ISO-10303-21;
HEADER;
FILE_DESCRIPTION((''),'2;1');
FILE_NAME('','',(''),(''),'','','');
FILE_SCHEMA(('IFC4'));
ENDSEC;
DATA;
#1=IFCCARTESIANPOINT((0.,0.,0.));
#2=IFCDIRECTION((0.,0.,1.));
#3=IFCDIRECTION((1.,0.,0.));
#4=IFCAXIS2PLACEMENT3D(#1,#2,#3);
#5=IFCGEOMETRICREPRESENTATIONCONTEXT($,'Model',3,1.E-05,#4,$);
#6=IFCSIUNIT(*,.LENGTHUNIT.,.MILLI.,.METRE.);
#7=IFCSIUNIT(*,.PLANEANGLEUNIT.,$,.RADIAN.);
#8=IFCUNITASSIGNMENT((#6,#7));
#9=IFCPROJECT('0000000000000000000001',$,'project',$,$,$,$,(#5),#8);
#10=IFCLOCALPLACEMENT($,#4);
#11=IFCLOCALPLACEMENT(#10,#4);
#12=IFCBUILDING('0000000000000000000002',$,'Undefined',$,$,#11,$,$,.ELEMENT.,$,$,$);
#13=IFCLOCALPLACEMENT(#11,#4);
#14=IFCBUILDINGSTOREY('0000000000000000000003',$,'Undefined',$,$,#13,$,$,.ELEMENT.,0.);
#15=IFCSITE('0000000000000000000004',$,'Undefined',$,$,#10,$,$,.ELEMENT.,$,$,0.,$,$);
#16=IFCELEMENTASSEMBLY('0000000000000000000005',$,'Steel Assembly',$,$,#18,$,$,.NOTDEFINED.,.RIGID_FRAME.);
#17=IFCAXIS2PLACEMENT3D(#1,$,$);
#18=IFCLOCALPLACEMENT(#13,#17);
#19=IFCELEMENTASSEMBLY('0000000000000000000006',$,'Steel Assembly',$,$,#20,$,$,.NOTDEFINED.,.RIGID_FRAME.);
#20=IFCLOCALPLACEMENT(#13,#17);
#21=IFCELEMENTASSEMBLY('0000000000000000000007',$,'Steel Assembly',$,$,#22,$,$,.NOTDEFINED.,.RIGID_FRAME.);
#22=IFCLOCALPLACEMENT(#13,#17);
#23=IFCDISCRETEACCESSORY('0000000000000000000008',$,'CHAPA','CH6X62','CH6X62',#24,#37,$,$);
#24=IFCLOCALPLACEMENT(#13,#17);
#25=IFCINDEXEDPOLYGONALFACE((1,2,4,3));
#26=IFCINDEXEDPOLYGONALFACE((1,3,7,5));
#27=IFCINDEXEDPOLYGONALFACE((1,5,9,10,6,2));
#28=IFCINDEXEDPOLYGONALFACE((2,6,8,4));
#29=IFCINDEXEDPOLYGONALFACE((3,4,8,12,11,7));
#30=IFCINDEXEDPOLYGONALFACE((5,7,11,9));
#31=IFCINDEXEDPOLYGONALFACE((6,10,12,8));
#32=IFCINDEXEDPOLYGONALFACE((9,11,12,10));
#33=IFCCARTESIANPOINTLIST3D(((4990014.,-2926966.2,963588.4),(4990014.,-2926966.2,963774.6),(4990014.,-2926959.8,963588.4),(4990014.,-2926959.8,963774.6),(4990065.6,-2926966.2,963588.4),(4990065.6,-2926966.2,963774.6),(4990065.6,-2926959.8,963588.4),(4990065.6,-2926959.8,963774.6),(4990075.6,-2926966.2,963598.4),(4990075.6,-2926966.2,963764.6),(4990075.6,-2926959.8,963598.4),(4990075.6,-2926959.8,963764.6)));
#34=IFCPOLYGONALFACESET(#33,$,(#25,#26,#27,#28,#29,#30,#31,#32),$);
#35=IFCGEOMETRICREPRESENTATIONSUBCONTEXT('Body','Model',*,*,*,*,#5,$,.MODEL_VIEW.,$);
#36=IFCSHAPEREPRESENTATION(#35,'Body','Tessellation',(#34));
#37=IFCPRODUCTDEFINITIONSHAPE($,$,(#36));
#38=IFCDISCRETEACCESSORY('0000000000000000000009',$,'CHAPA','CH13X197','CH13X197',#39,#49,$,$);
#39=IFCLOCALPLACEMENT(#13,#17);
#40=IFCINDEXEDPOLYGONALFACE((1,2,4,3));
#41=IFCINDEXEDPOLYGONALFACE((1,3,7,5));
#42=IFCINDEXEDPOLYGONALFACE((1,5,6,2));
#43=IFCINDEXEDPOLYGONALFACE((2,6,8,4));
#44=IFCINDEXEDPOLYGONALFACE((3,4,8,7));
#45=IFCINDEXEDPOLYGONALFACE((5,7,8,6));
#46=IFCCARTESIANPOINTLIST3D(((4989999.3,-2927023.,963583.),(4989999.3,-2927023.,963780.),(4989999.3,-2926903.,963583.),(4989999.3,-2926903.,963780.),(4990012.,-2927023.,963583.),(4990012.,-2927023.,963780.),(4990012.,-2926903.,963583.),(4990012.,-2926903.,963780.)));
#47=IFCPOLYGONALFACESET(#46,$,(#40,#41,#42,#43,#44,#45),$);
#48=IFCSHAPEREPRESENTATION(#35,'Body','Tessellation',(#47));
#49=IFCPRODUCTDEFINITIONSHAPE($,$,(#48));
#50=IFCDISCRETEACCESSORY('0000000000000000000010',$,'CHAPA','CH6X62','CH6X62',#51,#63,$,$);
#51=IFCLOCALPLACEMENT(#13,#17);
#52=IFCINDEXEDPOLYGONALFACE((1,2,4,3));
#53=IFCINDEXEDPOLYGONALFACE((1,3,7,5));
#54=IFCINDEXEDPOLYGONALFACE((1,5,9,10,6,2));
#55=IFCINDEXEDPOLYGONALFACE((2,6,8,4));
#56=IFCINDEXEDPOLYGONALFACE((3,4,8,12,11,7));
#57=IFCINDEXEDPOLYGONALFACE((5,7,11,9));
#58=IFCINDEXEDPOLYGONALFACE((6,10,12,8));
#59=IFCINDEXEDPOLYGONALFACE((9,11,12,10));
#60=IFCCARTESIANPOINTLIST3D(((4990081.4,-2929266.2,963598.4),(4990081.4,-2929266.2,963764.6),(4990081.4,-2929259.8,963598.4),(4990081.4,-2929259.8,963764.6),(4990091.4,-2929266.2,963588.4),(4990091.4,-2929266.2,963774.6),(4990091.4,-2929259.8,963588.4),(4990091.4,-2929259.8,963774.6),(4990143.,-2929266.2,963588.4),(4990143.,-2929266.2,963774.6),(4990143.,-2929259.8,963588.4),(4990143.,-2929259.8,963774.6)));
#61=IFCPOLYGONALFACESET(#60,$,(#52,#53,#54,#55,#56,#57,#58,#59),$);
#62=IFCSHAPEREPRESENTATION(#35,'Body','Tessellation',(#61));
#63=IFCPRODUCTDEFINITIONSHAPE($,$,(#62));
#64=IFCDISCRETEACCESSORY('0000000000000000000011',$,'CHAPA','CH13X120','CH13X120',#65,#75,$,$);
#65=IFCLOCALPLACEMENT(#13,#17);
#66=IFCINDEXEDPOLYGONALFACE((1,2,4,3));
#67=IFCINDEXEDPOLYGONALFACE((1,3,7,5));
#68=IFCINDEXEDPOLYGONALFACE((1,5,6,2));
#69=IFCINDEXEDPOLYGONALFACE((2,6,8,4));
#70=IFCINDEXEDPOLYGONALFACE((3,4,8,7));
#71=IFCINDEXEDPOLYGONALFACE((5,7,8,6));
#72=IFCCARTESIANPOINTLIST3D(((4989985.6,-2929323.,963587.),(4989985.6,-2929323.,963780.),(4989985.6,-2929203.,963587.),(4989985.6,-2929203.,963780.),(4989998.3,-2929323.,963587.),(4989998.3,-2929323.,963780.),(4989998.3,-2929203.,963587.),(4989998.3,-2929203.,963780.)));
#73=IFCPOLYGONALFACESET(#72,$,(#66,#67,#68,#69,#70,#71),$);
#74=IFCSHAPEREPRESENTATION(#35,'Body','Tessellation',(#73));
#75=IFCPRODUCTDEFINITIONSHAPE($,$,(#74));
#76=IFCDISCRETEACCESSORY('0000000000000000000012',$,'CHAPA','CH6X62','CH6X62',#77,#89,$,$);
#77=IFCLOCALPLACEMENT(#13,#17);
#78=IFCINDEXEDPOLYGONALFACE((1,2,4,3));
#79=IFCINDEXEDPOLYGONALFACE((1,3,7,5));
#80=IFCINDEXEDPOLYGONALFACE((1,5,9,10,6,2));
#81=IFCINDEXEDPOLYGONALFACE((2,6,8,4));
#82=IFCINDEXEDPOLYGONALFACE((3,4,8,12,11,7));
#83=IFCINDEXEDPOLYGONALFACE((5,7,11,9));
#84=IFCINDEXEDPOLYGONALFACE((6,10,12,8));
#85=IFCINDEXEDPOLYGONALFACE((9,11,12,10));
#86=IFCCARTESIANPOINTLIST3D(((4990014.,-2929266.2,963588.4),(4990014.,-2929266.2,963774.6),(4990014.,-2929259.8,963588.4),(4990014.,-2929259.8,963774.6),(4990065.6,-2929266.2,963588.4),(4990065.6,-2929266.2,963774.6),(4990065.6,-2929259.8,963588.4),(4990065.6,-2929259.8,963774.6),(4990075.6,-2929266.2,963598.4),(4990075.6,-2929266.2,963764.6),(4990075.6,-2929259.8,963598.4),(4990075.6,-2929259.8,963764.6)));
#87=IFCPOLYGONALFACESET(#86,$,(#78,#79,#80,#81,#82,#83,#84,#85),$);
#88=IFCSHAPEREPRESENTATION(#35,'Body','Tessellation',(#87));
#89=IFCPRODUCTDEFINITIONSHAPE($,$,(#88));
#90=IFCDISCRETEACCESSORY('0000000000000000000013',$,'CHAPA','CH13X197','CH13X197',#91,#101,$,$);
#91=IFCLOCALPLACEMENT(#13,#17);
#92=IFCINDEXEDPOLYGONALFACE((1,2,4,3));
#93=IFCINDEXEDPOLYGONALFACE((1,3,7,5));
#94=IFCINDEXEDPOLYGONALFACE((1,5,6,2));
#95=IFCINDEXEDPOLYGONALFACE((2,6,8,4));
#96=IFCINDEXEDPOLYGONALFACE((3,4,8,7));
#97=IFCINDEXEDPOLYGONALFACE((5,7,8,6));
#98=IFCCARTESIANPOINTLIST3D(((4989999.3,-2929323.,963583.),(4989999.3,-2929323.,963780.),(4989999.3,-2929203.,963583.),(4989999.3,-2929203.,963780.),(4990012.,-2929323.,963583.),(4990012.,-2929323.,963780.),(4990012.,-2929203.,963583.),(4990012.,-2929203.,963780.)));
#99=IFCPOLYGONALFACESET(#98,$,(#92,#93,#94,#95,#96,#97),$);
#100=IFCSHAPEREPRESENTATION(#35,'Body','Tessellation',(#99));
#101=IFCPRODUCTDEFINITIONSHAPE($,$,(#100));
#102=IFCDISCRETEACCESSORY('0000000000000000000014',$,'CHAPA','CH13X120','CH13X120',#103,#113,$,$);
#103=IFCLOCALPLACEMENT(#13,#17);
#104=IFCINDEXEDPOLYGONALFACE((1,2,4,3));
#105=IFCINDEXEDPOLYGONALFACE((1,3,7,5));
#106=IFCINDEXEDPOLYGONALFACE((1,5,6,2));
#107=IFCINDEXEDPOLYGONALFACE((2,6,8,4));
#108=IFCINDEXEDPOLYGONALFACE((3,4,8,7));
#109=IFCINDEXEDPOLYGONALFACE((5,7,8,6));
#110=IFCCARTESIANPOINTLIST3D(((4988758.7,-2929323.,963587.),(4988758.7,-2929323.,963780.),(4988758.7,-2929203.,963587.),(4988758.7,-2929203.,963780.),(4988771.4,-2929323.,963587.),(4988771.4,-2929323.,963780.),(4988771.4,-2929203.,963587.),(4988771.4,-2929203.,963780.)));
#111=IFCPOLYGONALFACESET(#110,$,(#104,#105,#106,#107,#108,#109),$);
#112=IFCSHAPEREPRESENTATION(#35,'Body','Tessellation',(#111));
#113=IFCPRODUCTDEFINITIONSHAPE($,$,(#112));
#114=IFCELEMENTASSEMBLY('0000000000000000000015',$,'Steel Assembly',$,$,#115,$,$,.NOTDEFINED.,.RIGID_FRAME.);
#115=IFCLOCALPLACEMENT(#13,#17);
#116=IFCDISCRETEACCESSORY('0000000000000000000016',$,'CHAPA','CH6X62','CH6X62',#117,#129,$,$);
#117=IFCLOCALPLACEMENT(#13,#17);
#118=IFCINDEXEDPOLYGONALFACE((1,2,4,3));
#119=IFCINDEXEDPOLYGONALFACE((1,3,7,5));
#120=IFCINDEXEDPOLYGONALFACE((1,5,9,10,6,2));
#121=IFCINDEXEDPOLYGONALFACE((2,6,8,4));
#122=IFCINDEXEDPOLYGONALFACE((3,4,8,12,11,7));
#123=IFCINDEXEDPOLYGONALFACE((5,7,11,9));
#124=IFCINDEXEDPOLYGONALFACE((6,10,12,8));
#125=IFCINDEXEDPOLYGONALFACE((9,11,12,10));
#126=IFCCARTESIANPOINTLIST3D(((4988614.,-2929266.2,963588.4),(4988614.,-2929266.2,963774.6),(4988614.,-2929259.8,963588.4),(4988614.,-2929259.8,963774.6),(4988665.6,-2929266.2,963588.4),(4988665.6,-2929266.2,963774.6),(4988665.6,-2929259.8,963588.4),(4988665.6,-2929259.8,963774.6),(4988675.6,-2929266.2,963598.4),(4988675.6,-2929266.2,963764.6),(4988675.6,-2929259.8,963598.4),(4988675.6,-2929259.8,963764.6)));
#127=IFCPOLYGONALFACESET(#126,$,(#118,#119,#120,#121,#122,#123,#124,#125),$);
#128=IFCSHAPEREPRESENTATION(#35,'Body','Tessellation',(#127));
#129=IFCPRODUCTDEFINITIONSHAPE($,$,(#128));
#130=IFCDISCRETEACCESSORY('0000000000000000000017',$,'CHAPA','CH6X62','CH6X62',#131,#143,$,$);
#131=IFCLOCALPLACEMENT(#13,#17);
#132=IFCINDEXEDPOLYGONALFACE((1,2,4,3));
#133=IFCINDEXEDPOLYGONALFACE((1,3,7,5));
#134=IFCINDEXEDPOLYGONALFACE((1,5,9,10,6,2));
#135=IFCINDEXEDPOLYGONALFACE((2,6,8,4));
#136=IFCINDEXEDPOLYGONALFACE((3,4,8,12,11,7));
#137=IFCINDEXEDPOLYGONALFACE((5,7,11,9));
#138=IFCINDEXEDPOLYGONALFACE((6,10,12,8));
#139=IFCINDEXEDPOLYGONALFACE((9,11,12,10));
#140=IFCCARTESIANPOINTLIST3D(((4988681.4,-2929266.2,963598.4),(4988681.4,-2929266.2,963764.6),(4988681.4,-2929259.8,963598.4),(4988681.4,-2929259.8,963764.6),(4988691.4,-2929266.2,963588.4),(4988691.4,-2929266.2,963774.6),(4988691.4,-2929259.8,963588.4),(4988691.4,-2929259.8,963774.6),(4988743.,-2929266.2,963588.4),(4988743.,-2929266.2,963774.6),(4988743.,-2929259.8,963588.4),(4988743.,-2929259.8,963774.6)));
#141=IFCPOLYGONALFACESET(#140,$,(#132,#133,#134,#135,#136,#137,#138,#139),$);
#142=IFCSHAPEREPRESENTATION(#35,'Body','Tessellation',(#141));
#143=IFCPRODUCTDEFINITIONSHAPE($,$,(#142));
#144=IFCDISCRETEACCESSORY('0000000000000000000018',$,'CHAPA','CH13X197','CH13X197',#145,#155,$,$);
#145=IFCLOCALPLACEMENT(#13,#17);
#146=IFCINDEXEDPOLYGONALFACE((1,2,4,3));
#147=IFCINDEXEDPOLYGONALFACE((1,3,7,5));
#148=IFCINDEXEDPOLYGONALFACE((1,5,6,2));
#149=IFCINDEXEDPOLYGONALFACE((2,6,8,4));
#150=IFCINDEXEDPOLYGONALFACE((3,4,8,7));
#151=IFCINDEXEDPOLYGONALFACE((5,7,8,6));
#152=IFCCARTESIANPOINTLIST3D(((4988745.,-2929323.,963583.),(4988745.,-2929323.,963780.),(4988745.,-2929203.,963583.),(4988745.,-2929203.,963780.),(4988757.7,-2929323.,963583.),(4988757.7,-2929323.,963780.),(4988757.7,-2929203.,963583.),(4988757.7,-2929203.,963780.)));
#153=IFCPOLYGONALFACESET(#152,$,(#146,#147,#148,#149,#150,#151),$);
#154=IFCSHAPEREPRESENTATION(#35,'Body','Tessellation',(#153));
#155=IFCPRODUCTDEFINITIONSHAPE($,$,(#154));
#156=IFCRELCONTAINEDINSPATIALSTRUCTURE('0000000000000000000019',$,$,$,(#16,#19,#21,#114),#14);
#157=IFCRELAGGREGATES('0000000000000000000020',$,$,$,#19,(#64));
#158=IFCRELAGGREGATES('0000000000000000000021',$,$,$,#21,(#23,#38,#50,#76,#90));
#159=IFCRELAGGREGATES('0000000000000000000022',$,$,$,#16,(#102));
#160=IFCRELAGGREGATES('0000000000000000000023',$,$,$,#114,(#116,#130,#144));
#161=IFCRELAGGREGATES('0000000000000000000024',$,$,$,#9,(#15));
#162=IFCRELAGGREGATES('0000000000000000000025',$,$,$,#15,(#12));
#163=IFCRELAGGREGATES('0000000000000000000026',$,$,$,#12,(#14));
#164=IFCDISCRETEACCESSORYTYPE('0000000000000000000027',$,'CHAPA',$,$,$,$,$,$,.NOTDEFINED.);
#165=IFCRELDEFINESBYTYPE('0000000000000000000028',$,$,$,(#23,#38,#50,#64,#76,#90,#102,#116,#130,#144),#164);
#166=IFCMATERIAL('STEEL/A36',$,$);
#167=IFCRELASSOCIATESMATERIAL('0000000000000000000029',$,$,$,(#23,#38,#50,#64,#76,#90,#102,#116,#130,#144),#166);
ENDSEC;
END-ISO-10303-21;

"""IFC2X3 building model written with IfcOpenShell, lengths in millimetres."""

from ifc_helpers import new_model, si_unit, frame, origin_with_axes, place, context, subcontext, project, spatial, polyline, outline, extrude, material, type_object, element, aggregate, save


model = new_model("IFC2X3")

# Units and contexts
model_context = context("Model", 3, precision=1e-05, world=origin_with_axes())
body_context = subcontext(model_context, "Body", "Model", "MODEL_VIEW")
ifc_project = project(units=[si_unit("LENGTHUNIT", "METRE", prefix="MILLI"), si_unit("PLANEANGLEUNIT", "RADIAN")], contexts=[model_context])

# Site, building, storey
site_placement = place(None, origin_with_axes())
site = spatial("IfcSite", under=ifc_project, at=site_placement, Name="Undefined", CompositionType="ELEMENT", RefElevation=0.0)
building_placement = place(site_placement, origin_with_axes())
building = spatial("IfcBuilding", under=site, at=building_placement, Name="Undefined", CompositionType="ELEMENT")
storey_placement = place(building_placement, origin_with_axes())
storey = spatial("IfcBuildingStorey", under=building, at=storey_placement, Name="Undefined", CompositionType="ELEMENT", Elevation=0.0)

# Element assemblies
assembly_1_placement = place(storey_placement, origin_with_axes())
assembly_1 = element("IfcElementAssembly", 1, at=assembly_1_placement, inside=storey, Name="Steel Assembly", AssemblyPlace="NOTDEFINED", PredefinedType="RIGID_FRAME")
ifc_material_1 = material(Name="STEEL/A36")
discrete_accessory_type = type_object("IfcDiscreteAccessoryType", Name="CHAPA")
assembly_2_placement = place(storey_placement, origin_with_axes())
assembly_2 = element("IfcElementAssembly", 2, at=assembly_2_placement, inside=storey, Name="Steel Assembly", AssemblyPlace="NOTDEFINED", PredefinedType="RIGID_FRAME")

# Element assembly, discrete accessories
assembly_3_placement = place(storey_placement, origin_with_axes())
assembly_3 = element("IfcElementAssembly", 3, at=assembly_3_placement, inside=storey, Name="Steel Assembly", AssemblyPlace="NOTDEFINED", PredefinedType="RIGID_FRAME")
discrete_accessory_1_placement = place(assembly_3_placement, frame((4990075.6, -2926963.0, 963774.6), z_axis=(0.0, -1.0, 0.0), x_axis=(-1.0, 0.0, 0.0)))
discrete_accessory_1 = element("IfcDiscreteAccessory", 4, at=discrete_accessory_1_placement, type_object=discrete_accessory_type, material=ifc_material_1, Name="CHAPA", Description="CH6X62", ObjectType="CH6X62", context=body_context, shape_type="SweptSolid", body=[
    extrude(outline(polyline([(0.0, 10.0), (10.0, 0.0), (61.6, 0.0), (61.6, 186.2), (10.0, 186.2), (0.0, 176.2), (0.0, 10.0)])), frame((0.0, 0.0, -3.2), z_axis=(0.0, 0.0, 1.0), x_axis=(1.0, 0.0, 0.0)), (0.0, 0.0, 1.0), 6.4),
])
discrete_accessory_2_placement = place(assembly_3_placement, frame((4990005.6, -2926963.0, 963780.0), z_axis=(-1.0, 0.0, 0.0), x_axis=(0.0, 0.0, -1.0)))
discrete_accessory_2 = element("IfcDiscreteAccessory", 5, at=discrete_accessory_2_placement, type_object=discrete_accessory_type, material=ifc_material_1, Name="CHAPA", Description="CH13X197", ObjectType="CH13X197", context=body_context, shape_type="SweptSolid", body=[
    extrude(outline(polyline([(197.0, 60.0), (197.0, -60.0), (0.0, -60.0), (0.0, 60.0), (197.0, 60.0)])), frame((0.0, 0.0, -6.3), z_axis=(0.0, 0.0, 1.0), x_axis=(1.0, 0.0, 0.0)), (0.0, 0.0, 1.0), 12.7),
])
discrete_accessory_3_placement = place(assembly_3_placement, frame((4990081.4, -2929263.0, 963774.6), z_axis=(0.0, 1.0, 0.0), x_axis=(1.0, 0.0, 0.0)))
discrete_accessory_3 = element("IfcDiscreteAccessory", 6, at=discrete_accessory_3_placement, type_object=discrete_accessory_type, material=ifc_material_1, Name="CHAPA", Description="CH6X62", ObjectType="CH6X62", context=body_context, shape_type="SweptSolid", body=[
    extrude(outline(polyline([(0.0, 10.0), (10.0, 0.0), (61.6, 0.0), (61.6, 186.2), (10.0, 186.2), (0.0, 176.2), (0.0, 10.0)])), frame((0.0, 0.0, -3.2), z_axis=(0.0, 0.0, 1.0), x_axis=(1.0, 0.0, 0.0)), (0.0, 0.0, 1.0), 6.4),
])

# Discrete accessories
discrete_accessory_4_placement = place(assembly_2_placement, frame((4989991.9, -2929263.0, 963780.0), z_axis=(-1.0, 0.0, 0.0), x_axis=(0.0, 0.0, -1.0)))
discrete_accessory_4 = element("IfcDiscreteAccessory", 7, at=discrete_accessory_4_placement, type_object=discrete_accessory_type, material=ifc_material_1, Name="CHAPA", Description="CH13X120", ObjectType="CH13X120", context=body_context, shape_type="SweptSolid", body=[
    extrude(outline(polyline([(193.0, 60.0), (193.0, -60.0), (0.0, -60.0), (0.0, 60.0), (193.0, 60.0)])), frame((0.0, 0.0, -6.3), z_axis=(0.0, 0.0, 1.0), x_axis=(1.0, 0.0, 0.0)), (0.0, 0.0, 1.0), 12.7),
])
aggregate(assembly_2, [discrete_accessory_4])
discrete_accessory_5_placement = place(assembly_3_placement, frame((4990075.6, -2929263.0, 963774.6), z_axis=(0.0, -1.0, 0.0), x_axis=(-1.0, 0.0, 0.0)))
discrete_accessory_5 = element("IfcDiscreteAccessory", 8, at=discrete_accessory_5_placement, type_object=discrete_accessory_type, material=ifc_material_1, Name="CHAPA", Description="CH6X62", ObjectType="CH6X62", context=body_context, shape_type="SweptSolid", body=[
    extrude(outline(polyline([(0.0, 10.0), (10.0, 0.0), (61.6, 0.0), (61.6, 186.2), (10.0, 186.2), (0.0, 176.2), (0.0, 10.0)])), frame((0.0, 0.0, -3.2), z_axis=(0.0, 0.0, 1.0), x_axis=(1.0, 0.0, 0.0)), (0.0, 0.0, 1.0), 6.4),
])
discrete_accessory_6_placement = place(assembly_3_placement, frame((4990005.6, -2929263.0, 963780.0), z_axis=(-1.0, 0.0, 0.0), x_axis=(0.0, 0.0, -1.0)))
discrete_accessory_6 = element("IfcDiscreteAccessory", 9, at=discrete_accessory_6_placement, type_object=discrete_accessory_type, material=ifc_material_1, Name="CHAPA", Description="CH13X197", ObjectType="CH13X197", context=body_context, shape_type="SweptSolid", body=[
    extrude(outline(polyline([(197.0, 60.0), (197.0, -60.0), (0.0, -60.0), (0.0, 60.0), (197.0, 60.0)])), frame((0.0, 0.0, -6.3), z_axis=(0.0, 0.0, 1.0), x_axis=(1.0, 0.0, 0.0)), (0.0, 0.0, 1.0), 12.7),
])
aggregate(assembly_3, [discrete_accessory_1, discrete_accessory_2, discrete_accessory_3, discrete_accessory_5, discrete_accessory_6])
discrete_accessory_7_placement = place(assembly_1_placement, frame((4988765.0, -2929263.0, 963780.0), z_axis=(1.0, 0.0, 0.0), x_axis=(0.0, 0.0, -1.0)))
discrete_accessory_7 = element("IfcDiscreteAccessory", 10, at=discrete_accessory_7_placement, type_object=discrete_accessory_type, material=ifc_material_1, Name="CHAPA", Description="CH13X120", ObjectType="CH13X120", context=body_context, shape_type="SweptSolid", body=[
    extrude(outline(polyline([(193.0, -60.0), (0.0, -60.0), (0.0, 60.0), (193.0, 60.0), (193.0, -60.0)])), frame((0.0, 0.0, -6.3), z_axis=(0.0, 0.0, 1.0), x_axis=(1.0, 0.0, 0.0)), (0.0, 0.0, 1.0), 12.7),
])
aggregate(assembly_1, [discrete_accessory_7])

# Element assembly, discrete accessories
assembly_4_placement = place(storey_placement, origin_with_axes())
assembly_4 = element("IfcElementAssembly", 11, at=assembly_4_placement, inside=storey, Name="Steel Assembly", AssemblyPlace="NOTDEFINED", PredefinedType="RIGID_FRAME")
discrete_accessory_8_placement = place(assembly_4_placement, frame((4988675.6, -2929263.0, 963774.6), z_axis=(0.0, -1.0, 0.0), x_axis=(-1.0, 0.0, 0.0)))
discrete_accessory_8 = element("IfcDiscreteAccessory", 12, at=discrete_accessory_8_placement, type_object=discrete_accessory_type, material=ifc_material_1, Name="CHAPA", Description="CH6X62", ObjectType="CH6X62", context=body_context, shape_type="SweptSolid", body=[
    extrude(outline(polyline([(0.0, 10.0), (10.0, 0.0), (61.6, 0.0), (61.6, 186.2), (10.0, 186.2), (0.0, 176.2), (0.0, 10.0)])), frame((0.0, 0.0, -3.2), z_axis=(0.0, 0.0, 1.0), x_axis=(1.0, 0.0, 0.0)), (0.0, 0.0, 1.0), 6.4),
])
discrete_accessory_9_placement = place(assembly_4_placement, frame((4988681.4, -2929263.0, 963774.6), z_axis=(0.0, 1.0, 0.0), x_axis=(1.0, 0.0, 0.0)))
discrete_accessory_9 = element("IfcDiscreteAccessory", 13, at=discrete_accessory_9_placement, type_object=discrete_accessory_type, material=ifc_material_1, Name="CHAPA", Description="CH6X62", ObjectType="CH6X62", context=body_context, shape_type="SweptSolid", body=[
    extrude(outline(polyline([(0.0, 10.0), (10.0, 0.0), (61.6, 0.0), (61.6, 186.2), (10.0, 186.2), (0.0, 176.2), (0.0, 10.0)])), frame((0.0, 0.0, -3.2), z_axis=(0.0, 0.0, 1.0), x_axis=(1.0, 0.0, 0.0)), (0.0, 0.0, 1.0), 6.4),
])
discrete_accessory_10_placement = place(assembly_4_placement, frame((4988751.3, -2929263.0, 963780.0), z_axis=(1.0, 0.0, 0.0), x_axis=(0.0, 0.0, -1.0)))
discrete_accessory_10 = element("IfcDiscreteAccessory", 14, at=discrete_accessory_10_placement, type_object=discrete_accessory_type, material=ifc_material_1, Name="CHAPA", Description="CH13X197", ObjectType="CH13X197", context=body_context, shape_type="SweptSolid", body=[
    extrude(outline(polyline([(197.0, -60.0), (0.0, -60.0), (0.0, 60.0), (197.0, 60.0), (197.0, -60.0)])), frame((0.0, 0.0, -6.3), z_axis=(0.0, 0.0, 1.0), x_axis=(1.0, 0.0, 0.0)), (0.0, 0.0, 1.0), 12.7),
])
aggregate(assembly_4, [discrete_accessory_8, discrete_accessory_9, discrete_accessory_10])

save(model, "model.ifc")
